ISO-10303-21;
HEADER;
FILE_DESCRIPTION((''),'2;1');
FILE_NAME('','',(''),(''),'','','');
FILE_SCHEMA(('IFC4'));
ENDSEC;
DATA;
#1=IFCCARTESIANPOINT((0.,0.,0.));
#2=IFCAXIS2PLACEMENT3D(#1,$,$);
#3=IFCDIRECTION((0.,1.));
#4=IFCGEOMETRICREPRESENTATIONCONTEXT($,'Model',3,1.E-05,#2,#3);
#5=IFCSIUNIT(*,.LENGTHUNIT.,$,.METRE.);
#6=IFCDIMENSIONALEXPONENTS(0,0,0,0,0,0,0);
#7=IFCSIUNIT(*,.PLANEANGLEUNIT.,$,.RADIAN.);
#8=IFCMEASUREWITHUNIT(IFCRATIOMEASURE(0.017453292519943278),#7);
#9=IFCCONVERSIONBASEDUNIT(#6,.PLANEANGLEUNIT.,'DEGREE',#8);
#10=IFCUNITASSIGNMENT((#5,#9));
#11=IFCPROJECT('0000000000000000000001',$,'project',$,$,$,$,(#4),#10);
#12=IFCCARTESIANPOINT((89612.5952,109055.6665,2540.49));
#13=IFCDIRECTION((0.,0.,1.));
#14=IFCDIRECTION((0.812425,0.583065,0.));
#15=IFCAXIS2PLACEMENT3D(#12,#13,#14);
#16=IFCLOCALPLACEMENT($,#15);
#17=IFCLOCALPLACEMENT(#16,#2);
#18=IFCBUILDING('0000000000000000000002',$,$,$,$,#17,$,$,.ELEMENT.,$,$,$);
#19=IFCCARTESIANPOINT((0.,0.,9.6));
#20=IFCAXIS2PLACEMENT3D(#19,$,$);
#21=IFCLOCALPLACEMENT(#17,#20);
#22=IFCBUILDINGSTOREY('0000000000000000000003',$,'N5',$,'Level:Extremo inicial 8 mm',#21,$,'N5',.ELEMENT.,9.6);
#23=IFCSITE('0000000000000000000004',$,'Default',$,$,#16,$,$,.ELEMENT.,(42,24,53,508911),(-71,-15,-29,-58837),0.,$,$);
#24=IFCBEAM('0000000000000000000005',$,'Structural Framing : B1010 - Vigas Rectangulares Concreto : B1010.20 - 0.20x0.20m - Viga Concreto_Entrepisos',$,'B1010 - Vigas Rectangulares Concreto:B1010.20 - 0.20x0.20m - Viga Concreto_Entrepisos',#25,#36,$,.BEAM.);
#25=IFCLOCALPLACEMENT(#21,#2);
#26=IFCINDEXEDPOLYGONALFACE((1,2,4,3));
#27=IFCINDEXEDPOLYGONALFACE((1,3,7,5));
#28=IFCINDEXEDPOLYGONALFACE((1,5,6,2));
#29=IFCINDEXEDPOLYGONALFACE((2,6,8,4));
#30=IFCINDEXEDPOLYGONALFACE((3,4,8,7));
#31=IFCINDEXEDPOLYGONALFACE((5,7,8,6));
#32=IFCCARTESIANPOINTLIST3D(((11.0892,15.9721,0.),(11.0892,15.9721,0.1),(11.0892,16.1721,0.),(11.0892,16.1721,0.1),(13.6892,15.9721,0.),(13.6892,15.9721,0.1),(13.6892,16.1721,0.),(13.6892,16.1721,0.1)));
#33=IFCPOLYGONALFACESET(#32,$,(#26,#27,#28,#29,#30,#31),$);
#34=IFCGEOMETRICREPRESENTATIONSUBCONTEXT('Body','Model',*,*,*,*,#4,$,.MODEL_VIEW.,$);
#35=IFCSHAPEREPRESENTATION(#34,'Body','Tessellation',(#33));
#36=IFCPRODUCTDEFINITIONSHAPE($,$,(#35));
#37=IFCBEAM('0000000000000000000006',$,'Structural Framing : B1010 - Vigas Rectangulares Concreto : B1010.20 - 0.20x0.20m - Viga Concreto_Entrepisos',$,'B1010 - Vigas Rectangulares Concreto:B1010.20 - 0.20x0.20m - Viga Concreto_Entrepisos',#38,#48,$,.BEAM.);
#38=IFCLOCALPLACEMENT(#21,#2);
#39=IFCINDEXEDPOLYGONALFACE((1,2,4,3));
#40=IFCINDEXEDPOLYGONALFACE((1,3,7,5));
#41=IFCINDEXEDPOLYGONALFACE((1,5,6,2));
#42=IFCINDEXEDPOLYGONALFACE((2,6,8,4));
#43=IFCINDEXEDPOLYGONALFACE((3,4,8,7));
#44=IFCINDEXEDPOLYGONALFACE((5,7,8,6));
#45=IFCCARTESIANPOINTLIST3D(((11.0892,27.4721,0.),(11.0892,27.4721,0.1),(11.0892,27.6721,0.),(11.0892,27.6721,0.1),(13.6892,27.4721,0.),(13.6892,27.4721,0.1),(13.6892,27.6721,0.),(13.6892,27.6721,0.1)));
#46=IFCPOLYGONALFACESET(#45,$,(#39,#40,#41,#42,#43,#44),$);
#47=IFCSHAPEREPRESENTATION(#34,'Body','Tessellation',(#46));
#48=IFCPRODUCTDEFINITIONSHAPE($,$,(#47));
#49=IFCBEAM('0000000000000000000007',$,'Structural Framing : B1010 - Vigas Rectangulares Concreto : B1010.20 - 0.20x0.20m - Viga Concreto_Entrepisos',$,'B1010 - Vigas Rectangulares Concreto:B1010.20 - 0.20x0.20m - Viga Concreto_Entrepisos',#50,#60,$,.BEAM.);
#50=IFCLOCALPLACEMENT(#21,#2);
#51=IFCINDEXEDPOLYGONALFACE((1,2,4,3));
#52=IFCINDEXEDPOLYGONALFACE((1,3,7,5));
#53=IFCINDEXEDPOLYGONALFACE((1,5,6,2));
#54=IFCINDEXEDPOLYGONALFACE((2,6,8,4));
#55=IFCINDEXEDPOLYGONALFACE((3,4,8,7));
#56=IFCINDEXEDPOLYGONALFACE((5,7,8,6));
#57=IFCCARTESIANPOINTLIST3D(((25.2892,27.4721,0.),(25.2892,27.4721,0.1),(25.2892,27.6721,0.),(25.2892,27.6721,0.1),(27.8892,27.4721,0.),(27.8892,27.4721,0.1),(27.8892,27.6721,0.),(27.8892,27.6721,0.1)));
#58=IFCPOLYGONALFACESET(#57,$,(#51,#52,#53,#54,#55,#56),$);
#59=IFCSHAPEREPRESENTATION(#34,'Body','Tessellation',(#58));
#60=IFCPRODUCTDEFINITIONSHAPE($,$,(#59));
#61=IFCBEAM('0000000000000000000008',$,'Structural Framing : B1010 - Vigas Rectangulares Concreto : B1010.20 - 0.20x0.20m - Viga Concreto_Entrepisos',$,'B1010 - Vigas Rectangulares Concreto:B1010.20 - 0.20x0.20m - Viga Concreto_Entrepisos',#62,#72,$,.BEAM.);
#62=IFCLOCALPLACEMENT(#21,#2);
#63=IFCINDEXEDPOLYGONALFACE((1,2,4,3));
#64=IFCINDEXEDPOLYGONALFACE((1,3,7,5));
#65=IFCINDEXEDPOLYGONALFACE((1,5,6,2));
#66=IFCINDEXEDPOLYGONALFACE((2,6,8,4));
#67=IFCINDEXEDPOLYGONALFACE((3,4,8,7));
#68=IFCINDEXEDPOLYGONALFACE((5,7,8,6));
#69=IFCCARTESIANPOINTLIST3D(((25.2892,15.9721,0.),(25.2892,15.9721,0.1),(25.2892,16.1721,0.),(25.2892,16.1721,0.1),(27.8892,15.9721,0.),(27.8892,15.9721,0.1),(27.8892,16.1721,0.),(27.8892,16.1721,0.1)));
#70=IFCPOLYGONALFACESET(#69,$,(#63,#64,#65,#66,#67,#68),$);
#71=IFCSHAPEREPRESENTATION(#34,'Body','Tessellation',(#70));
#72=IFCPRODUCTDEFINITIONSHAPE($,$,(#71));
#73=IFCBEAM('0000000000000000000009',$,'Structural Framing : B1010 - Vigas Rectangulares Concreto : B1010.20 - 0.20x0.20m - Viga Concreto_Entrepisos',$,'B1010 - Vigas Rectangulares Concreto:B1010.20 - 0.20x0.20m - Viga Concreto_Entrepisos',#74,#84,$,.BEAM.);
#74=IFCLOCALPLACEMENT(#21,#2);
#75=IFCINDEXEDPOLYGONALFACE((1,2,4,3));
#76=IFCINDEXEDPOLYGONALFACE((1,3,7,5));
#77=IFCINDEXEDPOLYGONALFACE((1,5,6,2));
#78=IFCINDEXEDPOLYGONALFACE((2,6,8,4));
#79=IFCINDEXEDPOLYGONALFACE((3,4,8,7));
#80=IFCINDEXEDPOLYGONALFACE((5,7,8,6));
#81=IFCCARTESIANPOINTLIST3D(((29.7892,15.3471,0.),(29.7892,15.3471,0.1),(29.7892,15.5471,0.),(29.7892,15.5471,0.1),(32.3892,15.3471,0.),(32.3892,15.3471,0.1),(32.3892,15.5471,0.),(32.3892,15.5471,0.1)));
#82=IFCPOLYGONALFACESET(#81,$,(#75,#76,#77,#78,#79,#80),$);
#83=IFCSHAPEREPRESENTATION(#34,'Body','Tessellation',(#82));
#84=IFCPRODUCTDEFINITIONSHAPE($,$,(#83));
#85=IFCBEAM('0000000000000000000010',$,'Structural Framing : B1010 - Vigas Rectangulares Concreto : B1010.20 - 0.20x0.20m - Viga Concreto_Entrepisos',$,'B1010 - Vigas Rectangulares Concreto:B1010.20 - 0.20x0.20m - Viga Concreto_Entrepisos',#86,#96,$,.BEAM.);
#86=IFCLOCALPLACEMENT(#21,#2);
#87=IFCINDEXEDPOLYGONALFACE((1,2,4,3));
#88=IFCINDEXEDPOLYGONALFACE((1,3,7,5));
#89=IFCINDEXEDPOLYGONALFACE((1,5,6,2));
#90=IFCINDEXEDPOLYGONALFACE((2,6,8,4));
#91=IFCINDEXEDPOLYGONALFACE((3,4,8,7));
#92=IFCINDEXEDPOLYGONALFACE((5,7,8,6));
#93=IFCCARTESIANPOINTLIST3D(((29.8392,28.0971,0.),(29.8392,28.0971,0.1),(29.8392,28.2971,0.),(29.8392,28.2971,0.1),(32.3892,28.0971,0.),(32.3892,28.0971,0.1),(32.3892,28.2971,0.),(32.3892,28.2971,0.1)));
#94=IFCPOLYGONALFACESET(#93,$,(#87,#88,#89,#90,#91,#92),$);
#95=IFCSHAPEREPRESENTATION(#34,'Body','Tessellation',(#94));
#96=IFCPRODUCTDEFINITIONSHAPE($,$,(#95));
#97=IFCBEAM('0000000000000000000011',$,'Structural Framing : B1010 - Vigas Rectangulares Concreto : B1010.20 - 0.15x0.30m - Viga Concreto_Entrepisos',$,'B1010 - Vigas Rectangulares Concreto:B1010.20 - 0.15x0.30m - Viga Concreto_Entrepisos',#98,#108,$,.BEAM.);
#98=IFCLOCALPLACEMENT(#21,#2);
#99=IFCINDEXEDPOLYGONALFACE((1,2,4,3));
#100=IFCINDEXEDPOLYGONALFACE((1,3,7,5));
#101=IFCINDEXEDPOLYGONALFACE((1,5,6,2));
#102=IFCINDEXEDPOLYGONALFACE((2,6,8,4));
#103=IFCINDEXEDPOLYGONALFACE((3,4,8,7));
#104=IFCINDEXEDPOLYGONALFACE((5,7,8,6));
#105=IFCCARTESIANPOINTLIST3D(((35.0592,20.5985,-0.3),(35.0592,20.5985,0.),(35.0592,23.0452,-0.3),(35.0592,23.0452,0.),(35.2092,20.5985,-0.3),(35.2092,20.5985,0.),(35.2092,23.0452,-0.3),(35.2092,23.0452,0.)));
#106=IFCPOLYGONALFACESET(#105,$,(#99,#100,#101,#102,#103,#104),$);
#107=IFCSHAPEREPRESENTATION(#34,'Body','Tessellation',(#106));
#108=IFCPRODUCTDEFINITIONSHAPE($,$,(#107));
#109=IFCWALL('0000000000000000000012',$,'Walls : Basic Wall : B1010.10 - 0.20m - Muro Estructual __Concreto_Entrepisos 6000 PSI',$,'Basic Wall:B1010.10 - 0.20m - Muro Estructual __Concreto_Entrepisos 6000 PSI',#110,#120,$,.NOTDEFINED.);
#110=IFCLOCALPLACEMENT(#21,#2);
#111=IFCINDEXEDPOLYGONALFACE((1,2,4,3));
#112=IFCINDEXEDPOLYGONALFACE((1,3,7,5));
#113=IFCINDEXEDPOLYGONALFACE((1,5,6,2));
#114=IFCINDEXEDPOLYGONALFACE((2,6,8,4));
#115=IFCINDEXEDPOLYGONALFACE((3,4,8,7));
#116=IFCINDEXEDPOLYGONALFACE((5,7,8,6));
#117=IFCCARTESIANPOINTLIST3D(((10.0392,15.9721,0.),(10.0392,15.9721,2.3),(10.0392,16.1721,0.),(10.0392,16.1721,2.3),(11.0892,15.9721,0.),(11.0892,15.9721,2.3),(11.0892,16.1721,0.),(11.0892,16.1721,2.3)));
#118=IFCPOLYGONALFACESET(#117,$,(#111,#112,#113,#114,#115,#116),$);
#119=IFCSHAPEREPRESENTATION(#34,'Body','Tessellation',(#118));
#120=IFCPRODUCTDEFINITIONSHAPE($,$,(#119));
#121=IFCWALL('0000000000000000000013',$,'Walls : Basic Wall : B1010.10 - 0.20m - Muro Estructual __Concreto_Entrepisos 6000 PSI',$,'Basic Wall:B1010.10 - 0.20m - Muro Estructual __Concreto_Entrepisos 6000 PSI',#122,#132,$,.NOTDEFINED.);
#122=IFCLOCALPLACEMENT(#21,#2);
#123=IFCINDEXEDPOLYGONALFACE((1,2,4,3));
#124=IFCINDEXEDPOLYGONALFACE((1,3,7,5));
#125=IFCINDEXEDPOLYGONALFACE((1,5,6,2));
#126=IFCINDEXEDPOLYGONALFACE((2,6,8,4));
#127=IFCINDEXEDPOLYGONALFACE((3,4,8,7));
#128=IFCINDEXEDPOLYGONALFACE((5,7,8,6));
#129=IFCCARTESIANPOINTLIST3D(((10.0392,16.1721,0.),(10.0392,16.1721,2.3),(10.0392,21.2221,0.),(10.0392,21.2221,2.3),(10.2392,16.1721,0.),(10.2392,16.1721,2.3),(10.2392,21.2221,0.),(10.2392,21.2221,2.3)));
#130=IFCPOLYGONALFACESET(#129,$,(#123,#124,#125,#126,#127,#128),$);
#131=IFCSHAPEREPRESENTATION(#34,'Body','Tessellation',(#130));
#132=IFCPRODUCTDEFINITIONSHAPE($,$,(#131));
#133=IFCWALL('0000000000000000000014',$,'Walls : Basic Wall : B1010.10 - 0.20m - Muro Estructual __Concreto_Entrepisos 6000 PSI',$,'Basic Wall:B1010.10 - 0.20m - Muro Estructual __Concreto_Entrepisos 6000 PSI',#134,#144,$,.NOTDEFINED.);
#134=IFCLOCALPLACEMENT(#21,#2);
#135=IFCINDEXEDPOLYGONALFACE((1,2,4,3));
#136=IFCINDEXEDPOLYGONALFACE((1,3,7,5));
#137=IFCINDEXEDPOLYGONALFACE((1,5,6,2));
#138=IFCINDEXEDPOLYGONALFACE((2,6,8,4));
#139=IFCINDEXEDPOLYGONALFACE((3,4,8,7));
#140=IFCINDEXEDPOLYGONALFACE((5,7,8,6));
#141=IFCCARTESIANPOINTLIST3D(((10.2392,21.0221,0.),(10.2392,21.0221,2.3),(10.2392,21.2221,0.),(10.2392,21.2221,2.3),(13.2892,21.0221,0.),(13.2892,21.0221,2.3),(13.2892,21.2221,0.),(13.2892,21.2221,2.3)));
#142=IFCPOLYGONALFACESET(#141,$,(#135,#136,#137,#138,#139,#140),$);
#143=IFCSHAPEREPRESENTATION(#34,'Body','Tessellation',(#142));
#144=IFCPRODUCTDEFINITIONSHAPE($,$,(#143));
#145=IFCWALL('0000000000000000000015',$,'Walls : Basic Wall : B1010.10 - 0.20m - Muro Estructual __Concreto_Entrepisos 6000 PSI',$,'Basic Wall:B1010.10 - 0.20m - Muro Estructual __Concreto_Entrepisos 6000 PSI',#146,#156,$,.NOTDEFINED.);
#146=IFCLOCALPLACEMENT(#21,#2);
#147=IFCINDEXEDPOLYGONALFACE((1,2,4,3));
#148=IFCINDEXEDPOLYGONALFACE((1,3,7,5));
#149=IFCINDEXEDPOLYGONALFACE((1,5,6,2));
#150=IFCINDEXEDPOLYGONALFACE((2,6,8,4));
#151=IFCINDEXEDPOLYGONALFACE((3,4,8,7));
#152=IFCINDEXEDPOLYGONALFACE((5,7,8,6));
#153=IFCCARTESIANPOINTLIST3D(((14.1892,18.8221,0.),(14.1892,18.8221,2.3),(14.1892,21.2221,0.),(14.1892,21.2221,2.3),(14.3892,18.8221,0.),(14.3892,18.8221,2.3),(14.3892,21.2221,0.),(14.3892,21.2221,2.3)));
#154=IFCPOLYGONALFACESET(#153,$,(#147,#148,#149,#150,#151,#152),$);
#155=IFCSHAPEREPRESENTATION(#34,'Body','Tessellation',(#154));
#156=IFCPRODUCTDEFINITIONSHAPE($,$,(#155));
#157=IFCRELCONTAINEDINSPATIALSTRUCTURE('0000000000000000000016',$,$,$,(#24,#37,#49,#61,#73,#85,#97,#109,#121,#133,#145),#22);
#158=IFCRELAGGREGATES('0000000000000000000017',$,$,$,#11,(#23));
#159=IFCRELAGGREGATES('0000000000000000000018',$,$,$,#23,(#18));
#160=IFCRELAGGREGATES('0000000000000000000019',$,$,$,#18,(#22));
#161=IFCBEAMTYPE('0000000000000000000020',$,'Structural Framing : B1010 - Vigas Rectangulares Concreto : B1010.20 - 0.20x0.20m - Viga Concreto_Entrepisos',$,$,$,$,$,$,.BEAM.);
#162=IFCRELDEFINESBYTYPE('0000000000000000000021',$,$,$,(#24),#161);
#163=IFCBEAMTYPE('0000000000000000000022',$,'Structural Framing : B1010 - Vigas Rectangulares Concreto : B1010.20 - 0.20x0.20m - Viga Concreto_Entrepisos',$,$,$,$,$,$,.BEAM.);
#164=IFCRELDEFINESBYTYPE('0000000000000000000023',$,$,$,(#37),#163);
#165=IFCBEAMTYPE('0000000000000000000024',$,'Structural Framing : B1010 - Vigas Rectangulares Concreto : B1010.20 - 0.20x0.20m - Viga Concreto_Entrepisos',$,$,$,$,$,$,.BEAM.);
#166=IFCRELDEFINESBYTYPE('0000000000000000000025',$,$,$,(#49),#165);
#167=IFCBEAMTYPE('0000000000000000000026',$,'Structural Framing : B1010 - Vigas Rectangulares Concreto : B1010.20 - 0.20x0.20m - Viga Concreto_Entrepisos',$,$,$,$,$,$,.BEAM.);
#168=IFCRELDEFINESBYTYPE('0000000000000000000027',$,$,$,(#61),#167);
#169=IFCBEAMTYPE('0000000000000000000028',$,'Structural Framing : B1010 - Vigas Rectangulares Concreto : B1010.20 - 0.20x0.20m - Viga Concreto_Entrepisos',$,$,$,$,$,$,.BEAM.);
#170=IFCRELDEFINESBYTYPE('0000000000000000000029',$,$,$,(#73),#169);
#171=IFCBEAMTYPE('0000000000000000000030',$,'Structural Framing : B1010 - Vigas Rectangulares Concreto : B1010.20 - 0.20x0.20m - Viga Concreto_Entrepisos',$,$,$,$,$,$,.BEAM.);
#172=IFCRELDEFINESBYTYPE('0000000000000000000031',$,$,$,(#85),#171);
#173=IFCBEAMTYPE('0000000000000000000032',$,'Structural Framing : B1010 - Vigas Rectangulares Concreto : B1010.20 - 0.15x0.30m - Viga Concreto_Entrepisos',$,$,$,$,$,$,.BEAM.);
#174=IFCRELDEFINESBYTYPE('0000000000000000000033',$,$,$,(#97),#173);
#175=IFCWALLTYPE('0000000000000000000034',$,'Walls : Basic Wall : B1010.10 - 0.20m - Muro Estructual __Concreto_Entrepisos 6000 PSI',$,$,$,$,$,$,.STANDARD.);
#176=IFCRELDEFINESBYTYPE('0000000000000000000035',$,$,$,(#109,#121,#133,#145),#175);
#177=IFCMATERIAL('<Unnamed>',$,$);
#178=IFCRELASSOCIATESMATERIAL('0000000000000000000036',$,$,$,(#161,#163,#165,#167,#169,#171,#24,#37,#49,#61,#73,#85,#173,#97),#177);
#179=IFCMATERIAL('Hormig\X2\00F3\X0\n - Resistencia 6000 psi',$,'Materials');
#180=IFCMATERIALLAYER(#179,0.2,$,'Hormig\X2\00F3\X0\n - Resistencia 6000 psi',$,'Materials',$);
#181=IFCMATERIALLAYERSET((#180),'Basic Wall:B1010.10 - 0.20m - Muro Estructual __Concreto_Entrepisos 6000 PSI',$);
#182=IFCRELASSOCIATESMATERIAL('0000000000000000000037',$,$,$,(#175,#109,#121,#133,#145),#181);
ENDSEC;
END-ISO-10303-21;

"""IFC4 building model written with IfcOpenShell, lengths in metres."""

from ifc_helpers import new_model, entity, si_unit, converted_unit, direction, frame, frame_2d, origin, place, context, subcontext, project, spatial, polyline, segment, composite_curve, rectangle, outline, extrude, source, transform, mapped, material, layer, layer_set, layer_usage, material_profile, profile_set, profile_usage, type_object, type_shapes, element, save


model = new_model("IFC4")

# Units and contexts
model_context = context("Model", 3, precision=1e-05, world=origin(), true_north=direction((0.0, 1.0)))
body_context = subcontext(model_context, "Body", "Model", "MODEL_VIEW")
ifc_project = project(units=[si_unit("LENGTHUNIT", "METRE"), converted_unit("PLANEANGLEUNIT", "DEGREE", entity("IfcRatioMeasure", 0.017453292519943278), si_unit("PLANEANGLEUNIT", "RADIAN"), dimensions=[0, 0, 0, 0, 0, 0, 0])], contexts=[model_context])

# Site, building, storey
site_placement = place(None, frame((89612.5952, 109055.6665, 2540.49), z_axis=(0.0, 0.0, 1.0), x_axis=(0.812425, 0.583065, 0.0)))
site = spatial("IfcSite", under=ifc_project, at=site_placement, Name="Default", CompositionType="ELEMENT", RefLatitude=(42, 24, 53, 508911), RefLongitude=(-71, -15, -29, -58837), RefElevation=0.0)
building_placement = place(site_placement, origin())
building = spatial("IfcBuilding", under=site, at=building_placement, CompositionType="ELEMENT")
storey_placement = place(building_placement, frame((0.0, 0.0, 9.6)))
storey = spatial("IfcBuildingStorey", under=building, at=storey_placement, Name="N5", ObjectType="Level:Extremo inicial 8 mm", LongName="N5", CompositionType="ELEMENT", Elevation=9.6)

# Beams
ifc_material_1 = material(Name="<Unnamed>")
ifc_material_profile_1 = material_profile(ifc_material_1, outline(composite_curve([segment(polyline([(-0.1, 0.0, 0.0), (-0.1, 0.1, 0.0)]), True, "CONTINUOUS"), segment(polyline([(-0.1, 0.1, 0.0), (0.1, 0.1, 0.0)]), True, "CONTINUOUS"), segment(polyline([(0.1, 0.1, 0.0), (0.1, 0.0, 0.0)]), True, "CONTINUOUS"), segment(polyline([(0.1, 0.0, 0.0), (-0.1, 0.0, 0.0)]), True, "CONTINUOUS")], self_intersect=False), kind="CURVE"), Name="B1010.20 - 0.20x0.20m - Viga Concreto_Entrepisos")
ifc_material_profile_2 = material_profile(ifc_material_1, outline(composite_curve([segment(polyline([(-1.3, -0.1, 0.1), (-1.3, 0.1, 0.1)]), True, "CONTINUOUS"), segment(polyline([(-1.3, 0.1, 0.1), (-1.3, 0.1, -0.1)]), True, "CONTINUOUS"), segment(polyline([(-1.3, 0.1, -0.1), (-1.3, -0.1, -0.1)]), True, "CONTINUOUS"), segment(polyline([(-1.3, -0.1, -0.1), (-1.3, -0.1, 0.1)]), True, "CONTINUOUS")], self_intersect=False), kind="CURVE"), Name="B1010.20 - 0.20x0.20m - Viga Concreto_Entrepisos")
ifc_profile_set_1 = profile_set([ifc_material_profile_1, ifc_material_profile_2], Name="B1010.20 - 0.20x0.20m - Viga Concreto_Entrepisos")
ifc_profile_usage_1 = profile_usage(ifc_profile_set_1, cardinal=8)
beam_type_1 = type_object("IfcBeamType", Name="Structural Framing : B1010 - Vigas Rectangulares Concreto : B1010.20 - 0.20x0.20m - Viga Concreto_Entrepisos", PredefinedType="BEAM", material=ifc_profile_set_1)
shared_shape_1 = source(origin(), body_context, "Body", "SweptSolid", [
    extrude(rectangle(XDim=0.1, YDim=0.2, at=frame_2d((0.0, 0.0), x_axis=(1.0, 0.0))), frame((13.6892, 16.0721, 9.65), z_axis=(-1.0, 0.0, 0.0), x_axis=(0.0, 0.0, -1.0)), (0.0, 0.0, 1.0), 2.6),
])
type_shapes(beam_type_1, [shared_shape_1])
beam_1_placement = place(storey_placement, frame((0.0, 0.0, -9.6)))
element("IfcBeam", 1, at=beam_1_placement, inside=storey, type_object=beam_type_1, material=ifc_profile_usage_1, Name="Structural Framing : B1010 - Vigas Rectangulares Concreto : B1010.20 - 0.20x0.20m - Viga Concreto_Entrepisos", ObjectType="B1010 - Vigas Rectangulares Concreto:B1010.20 - 0.20x0.20m - Viga Concreto_Entrepisos", PredefinedType="BEAM", context=body_context, shape_type="MappedRepresentation", body=[
    mapped(shared_shape_1, transform((0.0, 0.0, 0.0), scale=1.0)),
])
ifc_profile_usage_2 = profile_usage(ifc_profile_set_1, cardinal=8)
beam_type_2 = type_object("IfcBeamType", Name="Structural Framing : B1010 - Vigas Rectangulares Concreto : B1010.20 - 0.20x0.20m - Viga Concreto_Entrepisos", PredefinedType="BEAM", material=ifc_profile_set_1)
shared_shape_2 = source(origin(), body_context, "Body", "SweptSolid", [
    extrude(rectangle(XDim=0.1, YDim=0.2, at=frame_2d((0.0, 0.0), x_axis=(1.0, 0.0))), frame((13.6892, 27.5721, 9.65), z_axis=(-1.0, 0.0, 0.0), x_axis=(0.0, 0.0, -1.0)), (0.0, 0.0, 1.0), 2.6),
])
type_shapes(beam_type_2, [shared_shape_2])
beam_2_placement = place(storey_placement, frame((0.0, 0.0, -9.6)))
element("IfcBeam", 2, at=beam_2_placement, inside=storey, type_object=beam_type_2, material=ifc_profile_usage_2, Name="Structural Framing : B1010 - Vigas Rectangulares Concreto : B1010.20 - 0.20x0.20m - Viga Concreto_Entrepisos", ObjectType="B1010 - Vigas Rectangulares Concreto:B1010.20 - 0.20x0.20m - Viga Concreto_Entrepisos", PredefinedType="BEAM", context=body_context, shape_type="MappedRepresentation", body=[
    mapped(shared_shape_2, transform((0.0, 0.0, 0.0), scale=1.0)),
])
ifc_profile_usage_3 = profile_usage(ifc_profile_set_1, cardinal=8)
beam_type_3 = type_object("IfcBeamType", Name="Structural Framing : B1010 - Vigas Rectangulares Concreto : B1010.20 - 0.20x0.20m - Viga Concreto_Entrepisos", PredefinedType="BEAM", material=ifc_profile_set_1)
shared_shape_3 = source(origin(), body_context, "Body", "SweptSolid", [
    extrude(rectangle(XDim=0.1, YDim=0.2, at=frame_2d((0.0, 0.0), x_axis=(1.0, 0.0))), frame((25.2892, 27.5721, 9.65), z_axis=(1.0, 0.0, 0.0), x_axis=(0.0, 0.0, -1.0)), (0.0, 0.0, 1.0), 2.6),
])
type_shapes(beam_type_3, [shared_shape_3])
beam_3_placement = place(storey_placement, frame((0.0, 0.0, -9.6)))
element("IfcBeam", 3, at=beam_3_placement, inside=storey, type_object=beam_type_3, material=ifc_profile_usage_3, Name="Structural Framing : B1010 - Vigas Rectangulares Concreto : B1010.20 - 0.20x0.20m - Viga Concreto_Entrepisos", ObjectType="B1010 - Vigas Rectangulares Concreto:B1010.20 - 0.20x0.20m - Viga Concreto_Entrepisos", PredefinedType="BEAM", context=body_context, shape_type="MappedRepresentation", body=[
    mapped(shared_shape_3, transform((0.0, 0.0, 0.0), scale=1.0)),
])
ifc_profile_usage_4 = profile_usage(ifc_profile_set_1, cardinal=8)
beam_type_4 = type_object("IfcBeamType", Name="Structural Framing : B1010 - Vigas Rectangulares Concreto : B1010.20 - 0.20x0.20m - Viga Concreto_Entrepisos", PredefinedType="BEAM", material=ifc_profile_set_1)
shared_shape_4 = source(origin(), body_context, "Body", "SweptSolid", [
    extrude(rectangle(XDim=0.1, YDim=0.2, at=frame_2d((0.0, 0.0), x_axis=(1.0, 0.0))), frame((25.2892, 16.0721, 9.65), z_axis=(1.0, 0.0, 0.0), x_axis=(0.0, 0.0, -1.0)), (0.0, 0.0, 1.0), 2.6),
])
type_shapes(beam_type_4, [shared_shape_4])
beam_4_placement = place(storey_placement, frame((0.0, 0.0, -9.6)))
element("IfcBeam", 4, at=beam_4_placement, inside=storey, type_object=beam_type_4, material=ifc_profile_usage_4, Name="Structural Framing : B1010 - Vigas Rectangulares Concreto : B1010.20 - 0.20x0.20m - Viga Concreto_Entrepisos", ObjectType="B1010 - Vigas Rectangulares Concreto:B1010.20 - 0.20x0.20m - Viga Concreto_Entrepisos", PredefinedType="BEAM", context=body_context, shape_type="MappedRepresentation", body=[
    mapped(shared_shape_4, transform((0.0, 0.0, 0.0), scale=1.0)),
])
ifc_profile_usage_5 = profile_usage(ifc_profile_set_1, cardinal=8)
beam_type_5 = type_object("IfcBeamType", Name="Structural Framing : B1010 - Vigas Rectangulares Concreto : B1010.20 - 0.20x0.20m - Viga Concreto_Entrepisos", PredefinedType="BEAM", material=ifc_profile_set_1)
shared_shape_5 = source(origin(), body_context, "Body", "SweptSolid", [
    extrude(rectangle(XDim=0.1, YDim=0.2, at=frame_2d((0.0, 0.0), x_axis=(1.0, 0.0))), frame((32.3892, 15.4471, 9.65), z_axis=(-1.0, 0.0, 0.0), x_axis=(0.0, 0.0, -1.0)), (0.0, 0.0, 1.0), 2.6),
])
type_shapes(beam_type_5, [shared_shape_5])
beam_5_placement = place(storey_placement, frame((0.0, 0.0, -9.6)))
element("IfcBeam", 5, at=beam_5_placement, inside=storey, type_object=beam_type_5, material=ifc_profile_usage_5, Name="Structural Framing : B1010 - Vigas Rectangulares Concreto : B1010.20 - 0.20x0.20m - Viga Concreto_Entrepisos", ObjectType="B1010 - Vigas Rectangulares Concreto:B1010.20 - 0.20x0.20m - Viga Concreto_Entrepisos", PredefinedType="BEAM", context=body_context, shape_type="MappedRepresentation", body=[
    mapped(shared_shape_5, transform((0.0, 0.0, 0.0), scale=1.0)),
])
ifc_profile_usage_6 = profile_usage(ifc_profile_set_1, cardinal=8)
beam_type_6 = type_object("IfcBeamType", Name="Structural Framing : B1010 - Vigas Rectangulares Concreto : B1010.20 - 0.20x0.20m - Viga Concreto_Entrepisos", PredefinedType="BEAM", material=ifc_profile_set_1)
shared_shape_6 = source(origin(), body_context, "Body", "SweptSolid", [
    extrude(rectangle(XDim=0.1, YDim=0.2, at=frame_2d((0.0, 0.0), x_axis=(1.0, 0.0))), frame((29.8392, 28.1971, 9.65), z_axis=(1.0, 0.0, 0.0), x_axis=(0.0, 0.0, -1.0)), (0.0, 0.0, 1.0), 2.55),
])
type_shapes(beam_type_6, [shared_shape_6])
beam_6_placement = place(storey_placement, frame((0.0, 0.0, -9.6)))
element("IfcBeam", 6, at=beam_6_placement, inside=storey, type_object=beam_type_6, material=ifc_profile_usage_6, Name="Structural Framing : B1010 - Vigas Rectangulares Concreto : B1010.20 - 0.20x0.20m - Viga Concreto_Entrepisos", ObjectType="B1010 - Vigas Rectangulares Concreto:B1010.20 - 0.20x0.20m - Viga Concreto_Entrepisos", PredefinedType="BEAM", context=body_context, shape_type="MappedRepresentation", body=[
    mapped(shared_shape_6, transform((0.0, 0.0, 0.0), scale=1.0)),
])
ifc_material_profile_3 = material_profile(ifc_material_1, outline(composite_curve([segment(polyline([(-0.075, -0.15, 0.0), (-0.075, 0.15, 0.0)]), True, "CONTINUOUS"), segment(polyline([(-0.075, 0.15, 0.0), (0.075, 0.15, 0.0)]), True, "CONTINUOUS"), segment(polyline([(0.075, 0.15, 0.0), (0.075, -0.15, 0.0)]), True, "CONTINUOUS"), segment(polyline([(0.075, -0.15, 0.0), (-0.075, -0.15, 0.0)]), True, "CONTINUOUS")], self_intersect=False), kind="CURVE"), Name="B1010.20 - 0.15x0.30m - Viga Concreto_Entrepisos")
ifc_material_profile_4 = material_profile(ifc_material_1, outline(composite_curve([segment(polyline([(1.2233, 0.075, 0.15), (1.2233, 0.075, -0.15)]), True, "CONTINUOUS"), segment(polyline([(1.2233, 0.075, -0.15), (-1.2233, 0.075, -0.15)]), True, "CONTINUOUS"), segment(polyline([(-1.2233, 0.075, -0.15), (-1.2233, 0.075, 0.15)]), True, "CONTINUOUS"), segment(polyline([(-1.2233, 0.075, 0.15), (1.2233, 0.075, 0.15)]), True, "CONTINUOUS")], self_intersect=False), kind="CURVE"), Name="B1010.20 - 0.15x0.30m - Viga Concreto_Entrepisos")
ifc_profile_set_2 = profile_set([ifc_material_profile_3, ifc_material_profile_4], Name="B1010.20 - 0.15x0.30m - Viga Concreto_Entrepisos")
ifc_profile_usage_7 = profile_usage(ifc_profile_set_2, cardinal=8)
beam_type_7 = type_object("IfcBeamType", Name="Structural Framing : B1010 - Vigas Rectangulares Concreto : B1010.20 - 0.15x0.30m - Viga Concreto_Entrepisos", PredefinedType="BEAM", material=ifc_profile_set_2)
shared_shape_7 = source(origin(), body_context, "Body", "SweptSolid", [
    extrude(rectangle(XDim=0.3, YDim=0.15, at=frame_2d((0.0, 0.0), x_axis=(0.0, 1.0))), frame((35.1342, 20.5985, 9.45), z_axis=(0.0, 1.0, 0.0), x_axis=(-1.0, 0.0, 0.0)), (0.0, 0.0, 1.0), 2.4467),
])
type_shapes(beam_type_7, [shared_shape_7])
beam_7_placement = place(storey_placement, frame((0.0, 0.0, -9.6)))
element("IfcBeam", 7, at=beam_7_placement, inside=storey, type_object=beam_type_7, material=ifc_profile_usage_7, Name="Structural Framing : B1010 - Vigas Rectangulares Concreto : B1010.20 - 0.15x0.30m - Viga Concreto_Entrepisos", ObjectType="B1010 - Vigas Rectangulares Concreto:B1010.20 - 0.15x0.30m - Viga Concreto_Entrepisos", PredefinedType="BEAM", context=body_context, shape_type="MappedRepresentation", body=[
    mapped(shared_shape_7, transform((0.0, 0.0, 0.0), scale=1.0)),
])

# Walls
ifc_material_2 = material(Name="Hormigón - Resistencia 6000 psi", Category="Materials")
ifc_layer_1 = layer(ifc_material_2, 0.2, Name="Hormigón - Resistencia 6000 psi", Category="Materials")
ifc_layer_set_1 = layer_set([ifc_layer_1], Name="Basic Wall:B1010.10 - 0.20m - Muro Estructual __Concreto_Entrepisos 6000 PSI")
ifc_layer_usage_1 = layer_usage(ifc_layer_set_1, "AXIS2", "NEGATIVE", 0.1)
wall_type_1 = type_object("IfcWallType", Name="Walls : Basic Wall : B1010.10 - 0.20m - Muro Estructual __Concreto_Entrepisos 6000 PSI", PredefinedType="STANDARD", material=ifc_layer_set_1)
wall_1_placement = place(storey_placement, frame((11.0892, 16.0721, 0.0), z_axis=(0.0, 0.0, 1.0), x_axis=(-1.0, 0.0, 0.0)))
element("IfcWall", 8, at=wall_1_placement, inside=storey, type_object=wall_type_1, material=ifc_layer_usage_1, Name="Walls : Basic Wall : B1010.10 - 0.20m - Muro Estructual __Concreto_Entrepisos 6000 PSI", ObjectType="Basic Wall:B1010.10 - 0.20m - Muro Estructual __Concreto_Entrepisos 6000 PSI", PredefinedType="NOTDEFINED", context=body_context, shape_type="SweptSolid", body=[
    extrude(rectangle(XDim=1.05, YDim=0.2, at=frame_2d((0.525, 0.0), x_axis=(-1.0, 0.0))), origin(), (0.0, 0.0, 1.0), 2.3),
])
ifc_layer_usage_2 = layer_usage(ifc_layer_set_1, "AXIS2", "NEGATIVE", 0.1)
wall_2_placement = place(storey_placement, frame((10.1392, 16.1721, 0.0), z_axis=(0.0, 0.0, 1.0), x_axis=(0.0, 1.0, 0.0)))
element("IfcWall", 9, at=wall_2_placement, inside=storey, type_object=wall_type_1, material=ifc_layer_usage_2, Name="Walls : Basic Wall : B1010.10 - 0.20m - Muro Estructual __Concreto_Entrepisos 6000 PSI", ObjectType="Basic Wall:B1010.10 - 0.20m - Muro Estructual __Concreto_Entrepisos 6000 PSI", PredefinedType="NOTDEFINED", context=body_context, shape_type="SweptSolid", body=[
    extrude(rectangle(XDim=5.05, YDim=0.2, at=frame_2d((2.525, 0.0), x_axis=(-1.0, 0.0))), origin(), (0.0, 0.0, 1.0), 2.3),
])
ifc_layer_usage_3 = layer_usage(ifc_layer_set_1, "AXIS2", "NEGATIVE", 0.1)
wall_3_placement = place(storey_placement, frame((10.2392, 21.1221, 0.0)))
element("IfcWall", 10, at=wall_3_placement, inside=storey, type_object=wall_type_1, material=ifc_layer_usage_3, Name="Walls : Basic Wall : B1010.10 - 0.20m - Muro Estructual __Concreto_Entrepisos 6000 PSI", ObjectType="Basic Wall:B1010.10 - 0.20m - Muro Estructual __Concreto_Entrepisos 6000 PSI", PredefinedType="NOTDEFINED", context=body_context, shape_type="SweptSolid", body=[
    extrude(rectangle(XDim=3.05, YDim=0.2, at=frame_2d((1.525, 0.0), x_axis=(-1.0, 0.0))), origin(), (0.0, 0.0, 1.0), 2.3),
])
ifc_layer_usage_4 = layer_usage(ifc_layer_set_1, "AXIS2", "NEGATIVE", 0.1)
wall_4_placement = place(storey_placement, frame((14.2892, 18.8221, 0.0), z_axis=(0.0, 0.0, 1.0), x_axis=(0.0, 1.0, 0.0)))
element("IfcWall", 11, at=wall_4_placement, inside=storey, type_object=wall_type_1, material=ifc_layer_usage_4, Name="Walls : Basic Wall : B1010.10 - 0.20m - Muro Estructual __Concreto_Entrepisos 6000 PSI", ObjectType="Basic Wall:B1010.10 - 0.20m - Muro Estructual __Concreto_Entrepisos 6000 PSI", PredefinedType="NOTDEFINED", context=body_context, shape_type="SweptSolid", body=[
    extrude(rectangle(XDim=2.4, YDim=0.2, at=frame_2d((1.2, 0.0), x_axis=(-1.0, 0.0))), origin(), (0.0, 0.0, 1.0), 2.3),
])

save(model, "model.ifc")
